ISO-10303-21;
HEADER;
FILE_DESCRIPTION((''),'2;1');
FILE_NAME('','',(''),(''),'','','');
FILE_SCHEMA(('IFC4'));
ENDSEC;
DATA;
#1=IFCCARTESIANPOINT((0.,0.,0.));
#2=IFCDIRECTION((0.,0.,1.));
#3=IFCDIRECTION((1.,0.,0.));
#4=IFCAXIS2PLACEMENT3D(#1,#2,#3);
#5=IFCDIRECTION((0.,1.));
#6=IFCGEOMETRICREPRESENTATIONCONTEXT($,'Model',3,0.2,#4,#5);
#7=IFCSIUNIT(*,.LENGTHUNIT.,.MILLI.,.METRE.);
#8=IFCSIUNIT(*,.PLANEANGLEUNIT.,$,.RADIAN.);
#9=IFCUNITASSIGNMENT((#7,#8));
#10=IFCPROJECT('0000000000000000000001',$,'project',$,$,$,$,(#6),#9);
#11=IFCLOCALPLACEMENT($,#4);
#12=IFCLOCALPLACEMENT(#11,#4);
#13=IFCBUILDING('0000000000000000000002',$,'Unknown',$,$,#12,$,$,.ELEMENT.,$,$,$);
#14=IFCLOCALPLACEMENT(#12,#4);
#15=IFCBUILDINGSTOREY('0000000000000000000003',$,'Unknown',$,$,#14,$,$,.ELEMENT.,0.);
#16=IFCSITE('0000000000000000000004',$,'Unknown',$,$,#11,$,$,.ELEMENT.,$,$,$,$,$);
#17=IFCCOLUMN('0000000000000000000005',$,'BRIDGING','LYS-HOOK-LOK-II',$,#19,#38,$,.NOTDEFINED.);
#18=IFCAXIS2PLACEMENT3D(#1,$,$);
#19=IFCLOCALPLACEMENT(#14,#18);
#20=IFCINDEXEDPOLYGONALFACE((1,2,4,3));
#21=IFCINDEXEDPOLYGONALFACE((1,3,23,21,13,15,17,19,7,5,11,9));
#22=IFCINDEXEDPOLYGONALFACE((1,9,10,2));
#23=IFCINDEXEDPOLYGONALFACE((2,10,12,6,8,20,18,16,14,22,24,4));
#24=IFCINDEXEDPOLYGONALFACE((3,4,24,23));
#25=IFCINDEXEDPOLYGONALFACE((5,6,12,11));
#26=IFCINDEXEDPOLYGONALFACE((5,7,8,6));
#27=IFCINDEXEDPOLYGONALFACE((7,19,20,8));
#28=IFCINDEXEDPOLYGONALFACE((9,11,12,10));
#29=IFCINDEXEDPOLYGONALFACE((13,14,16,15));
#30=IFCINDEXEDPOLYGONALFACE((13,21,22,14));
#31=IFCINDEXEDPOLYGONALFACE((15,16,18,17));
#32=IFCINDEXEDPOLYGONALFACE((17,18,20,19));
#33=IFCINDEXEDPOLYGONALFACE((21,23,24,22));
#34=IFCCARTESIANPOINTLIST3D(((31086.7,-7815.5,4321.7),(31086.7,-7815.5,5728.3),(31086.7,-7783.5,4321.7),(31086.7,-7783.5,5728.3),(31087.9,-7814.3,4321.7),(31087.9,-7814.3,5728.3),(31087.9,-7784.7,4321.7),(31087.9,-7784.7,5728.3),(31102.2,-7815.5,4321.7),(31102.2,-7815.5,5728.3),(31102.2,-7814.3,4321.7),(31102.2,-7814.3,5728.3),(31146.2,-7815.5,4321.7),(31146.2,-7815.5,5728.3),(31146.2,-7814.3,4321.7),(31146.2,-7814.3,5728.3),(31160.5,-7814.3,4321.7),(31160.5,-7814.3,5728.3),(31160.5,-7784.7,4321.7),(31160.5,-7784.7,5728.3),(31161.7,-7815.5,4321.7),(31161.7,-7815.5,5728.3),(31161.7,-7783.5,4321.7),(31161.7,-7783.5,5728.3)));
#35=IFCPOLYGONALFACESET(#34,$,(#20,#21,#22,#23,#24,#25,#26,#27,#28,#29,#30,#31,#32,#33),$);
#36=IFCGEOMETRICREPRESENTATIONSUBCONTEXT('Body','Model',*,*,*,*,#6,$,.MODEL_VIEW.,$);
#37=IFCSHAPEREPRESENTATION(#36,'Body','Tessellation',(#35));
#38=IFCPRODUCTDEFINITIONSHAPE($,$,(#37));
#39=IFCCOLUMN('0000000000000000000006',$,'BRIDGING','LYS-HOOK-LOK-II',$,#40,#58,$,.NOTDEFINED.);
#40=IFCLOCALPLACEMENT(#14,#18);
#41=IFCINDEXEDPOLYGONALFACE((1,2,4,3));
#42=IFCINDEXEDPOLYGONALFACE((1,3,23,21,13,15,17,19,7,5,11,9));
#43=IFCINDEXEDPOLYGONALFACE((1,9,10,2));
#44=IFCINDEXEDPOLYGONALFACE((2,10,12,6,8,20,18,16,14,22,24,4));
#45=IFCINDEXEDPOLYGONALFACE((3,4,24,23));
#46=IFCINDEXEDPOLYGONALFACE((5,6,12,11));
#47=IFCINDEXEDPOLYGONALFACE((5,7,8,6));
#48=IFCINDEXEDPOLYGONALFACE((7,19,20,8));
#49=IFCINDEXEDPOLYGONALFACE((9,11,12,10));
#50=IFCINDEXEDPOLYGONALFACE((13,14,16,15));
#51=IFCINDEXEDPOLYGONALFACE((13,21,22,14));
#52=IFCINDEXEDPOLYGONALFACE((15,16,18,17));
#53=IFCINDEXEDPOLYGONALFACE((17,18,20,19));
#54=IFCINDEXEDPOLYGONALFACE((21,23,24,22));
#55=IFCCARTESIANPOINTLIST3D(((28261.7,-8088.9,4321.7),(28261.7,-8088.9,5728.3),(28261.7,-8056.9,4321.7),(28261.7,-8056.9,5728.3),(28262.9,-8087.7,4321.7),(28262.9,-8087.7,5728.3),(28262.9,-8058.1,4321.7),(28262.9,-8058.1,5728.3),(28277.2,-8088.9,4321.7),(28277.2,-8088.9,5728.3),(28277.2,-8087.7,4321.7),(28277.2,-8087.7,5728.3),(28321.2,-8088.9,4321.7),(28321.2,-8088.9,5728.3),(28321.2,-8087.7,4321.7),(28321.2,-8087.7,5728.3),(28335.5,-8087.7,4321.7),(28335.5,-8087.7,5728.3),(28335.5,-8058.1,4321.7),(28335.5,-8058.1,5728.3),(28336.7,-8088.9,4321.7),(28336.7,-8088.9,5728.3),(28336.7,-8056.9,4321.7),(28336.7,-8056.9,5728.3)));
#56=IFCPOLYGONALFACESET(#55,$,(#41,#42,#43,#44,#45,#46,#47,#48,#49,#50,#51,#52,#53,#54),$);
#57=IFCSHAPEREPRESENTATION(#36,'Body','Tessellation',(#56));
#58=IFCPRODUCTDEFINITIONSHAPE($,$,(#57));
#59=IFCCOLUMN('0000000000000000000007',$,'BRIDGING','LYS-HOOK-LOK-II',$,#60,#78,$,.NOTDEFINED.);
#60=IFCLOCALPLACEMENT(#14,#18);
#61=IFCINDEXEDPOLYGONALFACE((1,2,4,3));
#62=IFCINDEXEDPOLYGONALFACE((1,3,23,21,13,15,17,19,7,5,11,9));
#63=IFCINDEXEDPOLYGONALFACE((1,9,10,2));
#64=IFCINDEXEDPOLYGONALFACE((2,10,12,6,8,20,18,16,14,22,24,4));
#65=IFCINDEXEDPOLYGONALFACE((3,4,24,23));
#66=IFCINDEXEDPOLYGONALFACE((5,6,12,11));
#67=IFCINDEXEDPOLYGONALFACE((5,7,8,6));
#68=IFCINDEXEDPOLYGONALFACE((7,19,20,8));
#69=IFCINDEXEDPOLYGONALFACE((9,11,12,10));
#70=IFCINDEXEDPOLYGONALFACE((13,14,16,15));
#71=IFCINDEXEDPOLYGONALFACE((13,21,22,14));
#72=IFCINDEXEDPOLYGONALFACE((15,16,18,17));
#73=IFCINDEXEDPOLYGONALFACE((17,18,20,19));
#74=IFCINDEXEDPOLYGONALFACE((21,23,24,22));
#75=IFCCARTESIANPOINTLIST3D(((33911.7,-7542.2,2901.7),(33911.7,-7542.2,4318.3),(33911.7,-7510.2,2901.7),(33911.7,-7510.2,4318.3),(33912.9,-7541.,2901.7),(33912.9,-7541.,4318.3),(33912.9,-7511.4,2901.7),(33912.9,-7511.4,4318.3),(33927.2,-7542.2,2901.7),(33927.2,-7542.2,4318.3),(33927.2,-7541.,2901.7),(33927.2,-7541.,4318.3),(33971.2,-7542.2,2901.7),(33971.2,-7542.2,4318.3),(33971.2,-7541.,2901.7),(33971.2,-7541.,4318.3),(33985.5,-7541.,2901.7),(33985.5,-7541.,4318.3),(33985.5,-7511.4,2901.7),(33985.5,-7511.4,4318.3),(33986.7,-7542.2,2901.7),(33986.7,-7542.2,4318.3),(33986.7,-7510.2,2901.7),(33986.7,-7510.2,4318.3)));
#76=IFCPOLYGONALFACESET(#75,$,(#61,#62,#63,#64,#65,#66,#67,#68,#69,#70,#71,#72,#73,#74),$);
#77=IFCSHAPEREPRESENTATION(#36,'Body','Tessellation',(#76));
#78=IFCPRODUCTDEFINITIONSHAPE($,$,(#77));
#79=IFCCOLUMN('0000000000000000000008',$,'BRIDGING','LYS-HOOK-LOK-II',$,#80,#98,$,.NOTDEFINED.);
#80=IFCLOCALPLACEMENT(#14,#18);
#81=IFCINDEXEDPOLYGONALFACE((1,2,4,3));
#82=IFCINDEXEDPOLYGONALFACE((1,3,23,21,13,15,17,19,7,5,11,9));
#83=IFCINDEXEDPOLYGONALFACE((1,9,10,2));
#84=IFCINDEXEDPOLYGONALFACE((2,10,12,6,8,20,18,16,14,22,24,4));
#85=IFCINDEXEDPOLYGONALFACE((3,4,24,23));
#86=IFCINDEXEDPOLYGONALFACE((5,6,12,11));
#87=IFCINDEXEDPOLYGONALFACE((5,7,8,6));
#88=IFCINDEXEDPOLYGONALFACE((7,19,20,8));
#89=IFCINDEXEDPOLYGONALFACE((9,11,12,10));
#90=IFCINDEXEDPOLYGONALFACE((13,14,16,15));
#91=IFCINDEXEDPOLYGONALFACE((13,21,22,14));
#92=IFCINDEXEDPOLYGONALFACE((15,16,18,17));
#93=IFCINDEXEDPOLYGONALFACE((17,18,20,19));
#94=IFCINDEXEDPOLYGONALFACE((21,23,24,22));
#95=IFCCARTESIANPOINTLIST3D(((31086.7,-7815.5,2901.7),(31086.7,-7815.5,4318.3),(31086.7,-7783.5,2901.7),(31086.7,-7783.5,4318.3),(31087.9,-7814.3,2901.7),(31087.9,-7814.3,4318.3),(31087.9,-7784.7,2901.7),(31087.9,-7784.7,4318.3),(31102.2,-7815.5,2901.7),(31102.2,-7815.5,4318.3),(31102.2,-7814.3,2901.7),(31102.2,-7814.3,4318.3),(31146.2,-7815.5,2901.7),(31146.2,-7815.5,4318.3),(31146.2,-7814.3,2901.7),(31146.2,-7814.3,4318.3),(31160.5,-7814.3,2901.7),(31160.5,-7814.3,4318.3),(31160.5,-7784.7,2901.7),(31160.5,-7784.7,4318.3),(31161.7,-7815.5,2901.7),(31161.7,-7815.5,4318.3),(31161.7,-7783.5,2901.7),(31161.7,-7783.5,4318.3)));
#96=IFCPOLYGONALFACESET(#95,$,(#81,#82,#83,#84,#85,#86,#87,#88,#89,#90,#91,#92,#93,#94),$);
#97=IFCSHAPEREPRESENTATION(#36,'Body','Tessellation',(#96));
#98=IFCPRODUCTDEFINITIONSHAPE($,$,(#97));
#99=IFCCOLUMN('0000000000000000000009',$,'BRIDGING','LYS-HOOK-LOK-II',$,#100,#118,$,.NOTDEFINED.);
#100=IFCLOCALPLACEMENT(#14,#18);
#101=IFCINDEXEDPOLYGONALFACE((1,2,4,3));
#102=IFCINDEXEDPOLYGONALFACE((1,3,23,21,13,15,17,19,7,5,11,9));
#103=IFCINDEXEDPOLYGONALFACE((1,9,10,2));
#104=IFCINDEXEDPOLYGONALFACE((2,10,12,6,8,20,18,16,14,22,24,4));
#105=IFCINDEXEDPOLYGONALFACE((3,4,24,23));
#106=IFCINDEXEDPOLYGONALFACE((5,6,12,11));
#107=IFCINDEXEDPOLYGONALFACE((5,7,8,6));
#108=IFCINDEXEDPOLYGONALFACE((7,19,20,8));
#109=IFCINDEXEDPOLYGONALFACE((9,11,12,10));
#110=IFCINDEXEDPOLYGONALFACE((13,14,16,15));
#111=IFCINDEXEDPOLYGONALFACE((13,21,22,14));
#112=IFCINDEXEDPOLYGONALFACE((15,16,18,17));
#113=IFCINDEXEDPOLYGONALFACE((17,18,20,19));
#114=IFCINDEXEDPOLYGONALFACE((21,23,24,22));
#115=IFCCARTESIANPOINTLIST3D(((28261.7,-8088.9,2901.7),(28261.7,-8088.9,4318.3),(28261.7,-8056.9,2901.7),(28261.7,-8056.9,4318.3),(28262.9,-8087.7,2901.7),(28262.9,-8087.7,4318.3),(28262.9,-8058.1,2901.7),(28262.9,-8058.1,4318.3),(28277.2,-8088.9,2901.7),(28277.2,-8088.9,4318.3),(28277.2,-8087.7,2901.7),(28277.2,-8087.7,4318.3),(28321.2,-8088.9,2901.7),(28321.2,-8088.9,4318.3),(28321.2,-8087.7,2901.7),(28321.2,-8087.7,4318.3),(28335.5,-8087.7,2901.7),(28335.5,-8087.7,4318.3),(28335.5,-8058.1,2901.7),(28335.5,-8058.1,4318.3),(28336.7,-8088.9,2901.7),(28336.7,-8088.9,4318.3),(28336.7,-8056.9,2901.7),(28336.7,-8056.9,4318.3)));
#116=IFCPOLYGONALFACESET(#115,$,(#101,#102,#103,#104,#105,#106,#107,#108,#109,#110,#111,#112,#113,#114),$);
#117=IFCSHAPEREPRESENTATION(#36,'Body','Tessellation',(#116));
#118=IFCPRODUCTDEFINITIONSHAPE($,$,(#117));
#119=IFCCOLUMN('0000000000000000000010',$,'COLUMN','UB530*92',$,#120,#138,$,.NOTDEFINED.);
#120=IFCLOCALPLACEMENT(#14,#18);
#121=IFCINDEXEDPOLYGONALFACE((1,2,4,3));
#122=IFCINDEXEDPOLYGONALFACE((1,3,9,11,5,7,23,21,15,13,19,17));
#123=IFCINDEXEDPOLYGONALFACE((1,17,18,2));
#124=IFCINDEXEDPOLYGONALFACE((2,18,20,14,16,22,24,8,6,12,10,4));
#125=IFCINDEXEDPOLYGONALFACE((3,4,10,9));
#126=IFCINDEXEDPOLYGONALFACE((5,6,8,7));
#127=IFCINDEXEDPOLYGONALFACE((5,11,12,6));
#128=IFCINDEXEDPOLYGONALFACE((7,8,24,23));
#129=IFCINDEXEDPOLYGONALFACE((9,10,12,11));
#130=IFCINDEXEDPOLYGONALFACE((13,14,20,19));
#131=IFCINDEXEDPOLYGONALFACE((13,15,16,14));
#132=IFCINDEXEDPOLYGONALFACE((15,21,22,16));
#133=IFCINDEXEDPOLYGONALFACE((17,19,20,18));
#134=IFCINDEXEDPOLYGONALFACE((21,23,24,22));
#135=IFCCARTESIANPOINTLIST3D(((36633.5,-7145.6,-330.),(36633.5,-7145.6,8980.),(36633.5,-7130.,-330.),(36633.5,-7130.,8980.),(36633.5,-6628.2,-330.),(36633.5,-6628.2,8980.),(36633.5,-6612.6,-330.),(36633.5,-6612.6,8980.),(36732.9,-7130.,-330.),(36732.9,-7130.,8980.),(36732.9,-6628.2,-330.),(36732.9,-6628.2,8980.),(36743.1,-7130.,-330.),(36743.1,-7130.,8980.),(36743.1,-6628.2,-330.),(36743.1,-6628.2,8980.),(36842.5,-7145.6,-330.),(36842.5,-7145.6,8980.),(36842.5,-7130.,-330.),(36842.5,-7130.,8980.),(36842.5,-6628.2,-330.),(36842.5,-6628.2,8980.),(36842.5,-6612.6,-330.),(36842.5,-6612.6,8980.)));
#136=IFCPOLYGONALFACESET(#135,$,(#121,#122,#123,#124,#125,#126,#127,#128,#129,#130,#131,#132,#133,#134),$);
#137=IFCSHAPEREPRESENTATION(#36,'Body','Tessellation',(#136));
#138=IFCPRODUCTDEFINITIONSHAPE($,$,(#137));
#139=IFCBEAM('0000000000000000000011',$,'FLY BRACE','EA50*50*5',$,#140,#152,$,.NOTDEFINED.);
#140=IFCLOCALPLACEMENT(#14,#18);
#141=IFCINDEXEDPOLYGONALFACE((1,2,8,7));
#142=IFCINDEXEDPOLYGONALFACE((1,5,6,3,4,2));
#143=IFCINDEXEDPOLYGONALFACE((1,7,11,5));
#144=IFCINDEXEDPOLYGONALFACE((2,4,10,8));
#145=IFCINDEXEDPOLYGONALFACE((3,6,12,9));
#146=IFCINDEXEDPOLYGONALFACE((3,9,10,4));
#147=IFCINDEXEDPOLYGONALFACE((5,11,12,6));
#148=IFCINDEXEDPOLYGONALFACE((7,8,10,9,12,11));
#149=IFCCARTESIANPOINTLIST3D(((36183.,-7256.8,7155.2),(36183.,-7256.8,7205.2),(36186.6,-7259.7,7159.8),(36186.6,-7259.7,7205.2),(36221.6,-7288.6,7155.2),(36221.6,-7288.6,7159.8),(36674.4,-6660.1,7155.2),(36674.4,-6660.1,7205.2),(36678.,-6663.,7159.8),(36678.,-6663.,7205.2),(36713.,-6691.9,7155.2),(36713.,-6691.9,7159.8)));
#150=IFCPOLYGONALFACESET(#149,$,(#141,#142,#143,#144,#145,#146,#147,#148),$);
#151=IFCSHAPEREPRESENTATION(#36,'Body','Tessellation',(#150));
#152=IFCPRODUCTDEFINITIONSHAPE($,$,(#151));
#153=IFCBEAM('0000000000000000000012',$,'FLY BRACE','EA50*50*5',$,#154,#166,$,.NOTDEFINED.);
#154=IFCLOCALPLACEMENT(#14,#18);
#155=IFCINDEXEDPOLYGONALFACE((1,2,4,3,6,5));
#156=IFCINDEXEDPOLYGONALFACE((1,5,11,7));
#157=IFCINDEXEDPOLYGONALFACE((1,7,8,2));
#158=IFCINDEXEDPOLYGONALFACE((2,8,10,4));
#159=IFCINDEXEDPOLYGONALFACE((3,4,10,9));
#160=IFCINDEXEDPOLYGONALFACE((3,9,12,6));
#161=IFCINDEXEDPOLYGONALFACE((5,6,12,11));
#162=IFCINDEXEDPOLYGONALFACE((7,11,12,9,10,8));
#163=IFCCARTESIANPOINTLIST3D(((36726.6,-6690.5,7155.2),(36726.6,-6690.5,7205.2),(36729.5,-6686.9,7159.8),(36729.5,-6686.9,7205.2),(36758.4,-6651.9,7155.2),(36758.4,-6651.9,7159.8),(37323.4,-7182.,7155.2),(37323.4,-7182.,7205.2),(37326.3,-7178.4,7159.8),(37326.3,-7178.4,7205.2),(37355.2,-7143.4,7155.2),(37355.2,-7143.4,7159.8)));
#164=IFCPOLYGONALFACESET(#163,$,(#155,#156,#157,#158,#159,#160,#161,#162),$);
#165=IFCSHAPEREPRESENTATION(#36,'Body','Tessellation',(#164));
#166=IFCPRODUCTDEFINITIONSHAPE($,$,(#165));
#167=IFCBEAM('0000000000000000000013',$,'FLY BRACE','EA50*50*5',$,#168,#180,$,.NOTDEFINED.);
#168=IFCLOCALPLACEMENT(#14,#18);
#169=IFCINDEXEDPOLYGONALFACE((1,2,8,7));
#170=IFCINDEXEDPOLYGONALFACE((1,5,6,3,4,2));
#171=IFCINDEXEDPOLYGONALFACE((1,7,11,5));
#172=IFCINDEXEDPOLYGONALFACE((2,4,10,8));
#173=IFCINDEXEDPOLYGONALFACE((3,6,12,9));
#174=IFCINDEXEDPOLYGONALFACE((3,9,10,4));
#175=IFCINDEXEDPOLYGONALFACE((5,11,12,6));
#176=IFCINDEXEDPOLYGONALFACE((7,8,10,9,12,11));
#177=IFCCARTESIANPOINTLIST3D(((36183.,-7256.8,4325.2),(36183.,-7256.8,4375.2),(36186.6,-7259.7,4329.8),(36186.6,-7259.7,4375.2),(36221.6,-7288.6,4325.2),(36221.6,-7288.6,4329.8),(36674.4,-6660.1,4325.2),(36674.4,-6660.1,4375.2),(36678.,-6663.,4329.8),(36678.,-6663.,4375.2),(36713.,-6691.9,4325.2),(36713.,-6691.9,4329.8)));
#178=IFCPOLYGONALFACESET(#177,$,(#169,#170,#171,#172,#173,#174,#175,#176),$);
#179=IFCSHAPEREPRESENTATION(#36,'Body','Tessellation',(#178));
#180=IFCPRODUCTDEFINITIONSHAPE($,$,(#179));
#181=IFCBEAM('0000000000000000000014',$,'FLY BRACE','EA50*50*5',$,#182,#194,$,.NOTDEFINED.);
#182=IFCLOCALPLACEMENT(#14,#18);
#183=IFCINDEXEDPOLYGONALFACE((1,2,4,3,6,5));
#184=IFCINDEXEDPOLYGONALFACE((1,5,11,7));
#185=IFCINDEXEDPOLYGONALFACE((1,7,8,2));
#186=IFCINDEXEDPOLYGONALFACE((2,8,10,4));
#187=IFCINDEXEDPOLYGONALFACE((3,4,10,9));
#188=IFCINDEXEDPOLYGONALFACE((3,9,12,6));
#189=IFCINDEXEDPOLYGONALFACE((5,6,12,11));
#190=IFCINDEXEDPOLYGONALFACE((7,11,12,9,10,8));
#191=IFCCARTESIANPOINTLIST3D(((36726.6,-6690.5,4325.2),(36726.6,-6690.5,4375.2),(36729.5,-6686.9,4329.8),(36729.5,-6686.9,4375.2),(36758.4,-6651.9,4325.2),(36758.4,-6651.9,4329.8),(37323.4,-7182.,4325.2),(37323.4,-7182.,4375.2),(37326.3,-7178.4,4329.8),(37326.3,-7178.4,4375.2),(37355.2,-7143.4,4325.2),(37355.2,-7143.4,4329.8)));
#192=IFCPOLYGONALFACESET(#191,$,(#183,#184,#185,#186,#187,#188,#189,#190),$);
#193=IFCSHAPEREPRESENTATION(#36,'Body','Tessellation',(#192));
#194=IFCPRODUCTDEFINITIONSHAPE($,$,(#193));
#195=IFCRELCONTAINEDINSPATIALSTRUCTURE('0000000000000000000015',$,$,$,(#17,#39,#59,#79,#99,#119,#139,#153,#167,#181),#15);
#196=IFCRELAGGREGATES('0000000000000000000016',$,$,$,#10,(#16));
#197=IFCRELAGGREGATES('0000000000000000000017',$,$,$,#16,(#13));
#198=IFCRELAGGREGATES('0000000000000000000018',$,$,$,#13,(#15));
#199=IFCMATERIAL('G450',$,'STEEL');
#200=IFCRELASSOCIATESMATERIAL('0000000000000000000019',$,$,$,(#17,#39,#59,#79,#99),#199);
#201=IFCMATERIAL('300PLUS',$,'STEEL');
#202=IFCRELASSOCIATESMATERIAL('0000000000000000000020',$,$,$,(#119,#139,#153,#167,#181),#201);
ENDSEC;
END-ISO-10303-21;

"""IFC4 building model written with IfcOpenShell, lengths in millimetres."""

from ifc_helpers import new_model, si_unit, direction, frame, origin_with_axes, place, context, subcontext, project, spatial, line, indexed_curve, outline, extrude, material, element, save


model = new_model("IFC4")

# Units and contexts
model_context = context("Model", 3, precision=0.2, world=origin_with_axes(), true_north=direction((0.0, 1.0)))
body_context = subcontext(model_context, "Body", "Model", "MODEL_VIEW")
ifc_project = project(units=[si_unit("LENGTHUNIT", "METRE", prefix="MILLI"), si_unit("PLANEANGLEUNIT", "RADIAN")], contexts=[model_context])

# Site, building, storey
site_placement = place(None, origin_with_axes())
site = spatial("IfcSite", under=ifc_project, at=site_placement, Name="Unknown", CompositionType="ELEMENT")
building_placement = place(site_placement, origin_with_axes())
building = spatial("IfcBuilding", under=site, at=building_placement, Name="Unknown", CompositionType="ELEMENT")
storey_placement = place(building_placement, origin_with_axes())
storey = spatial("IfcBuildingStorey", under=building, at=storey_placement, Name="Unknown", CompositionType="ELEMENT", Elevation=0.0)

# Columns
ifc_material_1 = material(Name="G450", Category="STEEL")
for number, where, z_axis, x_axis, name in (
    (1, (31124.2, -7799.5, 4321.7), (0.0, -1.0, 0.0), (0.0, 0.0, 1.0), "BRIDGING"),
    (2, (28299.2, -8072.9, 4321.7), (0.0, -1.0, 0.0), (0.0, 0.0, 1.0), "BRIDGING"),
):
    element("IfcColumn", number, at=place(storey_placement, frame(where, z_axis=z_axis, x_axis=x_axis)), inside=storey, material=ifc_material_1, Name=name, Description="LYS-HOOK-LOK-II", PredefinedType="NOTDEFINED", context=body_context, shape_type="SolidModel", body=[
        extrude(outline(indexed_curve([(16.0, -37.5), (16.0, -22.0), (14.8, -22.0), (14.8, -36.3), (-14.8, -36.3), (-14.8, 36.3), (14.8, 36.3), (14.8, 22.0), (16.0, 22.0), (16.0, 37.5), (-16.0, 37.5), (-16.0, -37.5)], segments=[line(1, 2, 3, 4, 5, 6, 7, 8, 9, 10, 11, 12, 1)])), frame((0.0, 0.0, 0.0), z_axis=(-1.0, 0.0, 0.0), x_axis=(0.0, 0.0, 1.0)), (0.0, 0.0, -1.0), 1406.6),
    ])
for number, where, z_axis, x_axis, name in (
    (3, (33949.2, -7526.2, 2901.7), (0.0, -1.0, 0.0), (0.0, 0.0, 1.0), "BRIDGING"),
    (4, (31124.2, -7799.5, 2901.7), (0.0, -1.0, 0.0), (0.0, 0.0, 1.0), "BRIDGING"),
    (5, (28299.2, -8072.9, 2901.7), (0.0, -1.0, 0.0), (0.0, 0.0, 1.0), "BRIDGING"),
):
    element("IfcColumn", number, at=place(storey_placement, frame(where, z_axis=z_axis, x_axis=x_axis)), inside=storey, material=ifc_material_1, Name=name, Description="LYS-HOOK-LOK-II", PredefinedType="NOTDEFINED", context=body_context, shape_type="SolidModel", body=[
        extrude(outline(indexed_curve([(16.0, -37.5), (16.0, -22.0), (14.8, -22.0), (14.8, -36.3), (-14.8, -36.3), (-14.8, 36.3), (14.8, 36.3), (14.8, 22.0), (16.0, 22.0), (16.0, 37.5), (-16.0, 37.5), (-16.0, -37.5)], segments=[line(1, 2, 3, 4, 5, 6, 7, 8, 9, 10, 11, 12, 1)])), frame((0.0, 0.0, 0.0), z_axis=(-1.0, 0.0, 0.0), x_axis=(0.0, 0.0, 1.0)), (0.0, 0.0, -1.0), 1416.6),
    ])
ifc_material_2 = material(Name="300PLUS", Category="STEEL")
column_placement = place(storey_placement, frame((36738.0, -6879.1, -330.0), z_axis=(-1.0, 0.0, 0.0), x_axis=(0.0, 0.0, 1.0)))
element("IfcColumn", 6, at=column_placement, inside=storey, material=ifc_material_2, Name="COLUMN", Description="UB530*92", PredefinedType="NOTDEFINED", context=body_context, shape_type="SolidModel", body=[
    extrude(outline(indexed_curve([(-104.5, -266.5), (104.5, -266.5), (104.5, -250.9), (5.1, -250.9), (5.1, 250.9), (104.5, 250.9), (104.5, 266.5), (-104.5, 266.5), (-104.5, 250.9), (-5.1, 250.9), (-5.1, -250.9), (-104.5, -250.9)], segments=[line(1, 2, 3, 4, 5, 6, 7, 8, 9, 10, 11, 12, 1)])), frame((0.0, 0.0, 0.0), z_axis=(-1.0, 0.0, 0.0), x_axis=(0.0, 0.0, 1.0)), (0.0, 0.0, -1.0), 9310.0),
])

# Beams
beam_1_placement = place(storey_placement, frame((36693.7, -6676.0, 7180.2), z_axis=(0.0, 0.0, 1.0), x_axis=(-0.635707, -0.77193, 0.0)))
element("IfcBeam", 7, at=beam_1_placement, inside=storey, material=ifc_material_2, Name="FLY BRACE", Description="EA50*50*5", PredefinedType="NOTDEFINED", context=body_context, shape_type="SolidModel", body=[
    extrude(outline(indexed_curve([(-25.0, -25.0), (25.0, -25.0), (25.0, -20.4), (-20.4, -20.4), (-20.4, 25.0), (-25.0, 25.0)], segments=[line(1, 2, 3, 4, 5, 6, 1)])), frame((0.0, 0.0, 0.0), z_axis=(-1.0, 0.0, 0.0), x_axis=(0.0, 0.0, 1.0)), (0.0, 0.0, -1.0), 773.0),
])
beam_2_placement = place(storey_placement, frame((36742.5, -6671.2, 7180.2), z_axis=(0.0, 0.0, 1.0), x_axis=(0.771919, -0.635721, 0.0)))
element("IfcBeam", 8, at=beam_2_placement, inside=storey, material=ifc_material_2, Name="FLY BRACE", Description="EA50*50*5", PredefinedType="NOTDEFINED", context=body_context, shape_type="SolidModel", body=[
    extrude(outline(indexed_curve([(-25.0, -25.0), (25.0, -25.0), (25.0, -20.4), (-20.4, -20.4), (-20.4, 25.0), (-25.0, 25.0)], segments=[line(1, 2, 3, 4, 5, 6, 1)])), frame((0.0, 0.0, 0.0), z_axis=(-1.0, 0.0, 0.0), x_axis=(0.0, 0.0, 1.0)), (0.0, 0.0, -1.0), 773.1),
])
beam_3_placement = place(storey_placement, frame((36693.7, -6676.0, 4350.2), z_axis=(0.0, 0.0, 1.0), x_axis=(-0.635707, -0.77193, 0.0)))
element("IfcBeam", 9, at=beam_3_placement, inside=storey, material=ifc_material_2, Name="FLY BRACE", Description="EA50*50*5", PredefinedType="NOTDEFINED", context=body_context, shape_type="SolidModel", body=[
    extrude(outline(indexed_curve([(-25.0, -25.0), (25.0, -25.0), (25.0, -20.4), (-20.4, -20.4), (-20.4, 25.0), (-25.0, 25.0)], segments=[line(1, 2, 3, 4, 5, 6, 1)])), frame((0.0, 0.0, 0.0), z_axis=(-1.0, 0.0, 0.0), x_axis=(0.0, 0.0, 1.0)), (0.0, 0.0, -1.0), 773.0),
])
beam_4_placement = place(storey_placement, frame((36742.5, -6671.2, 4350.2), z_axis=(0.0, 0.0, 1.0), x_axis=(0.771919, -0.635721, 0.0)))
element("IfcBeam", 10, at=beam_4_placement, inside=storey, material=ifc_material_2, Name="FLY BRACE", Description="EA50*50*5", PredefinedType="NOTDEFINED", context=body_context, shape_type="SolidModel", body=[
    extrude(outline(indexed_curve([(-25.0, -25.0), (25.0, -25.0), (25.0, -20.4), (-20.4, -20.4), (-20.4, 25.0), (-25.0, 25.0)], segments=[line(1, 2, 3, 4, 5, 6, 1)])), frame((0.0, 0.0, 0.0), z_axis=(-1.0, 0.0, 0.0), x_axis=(0.0, 0.0, 1.0)), (0.0, 0.0, -1.0), 773.1),
])

save(model, "model.ifc")
